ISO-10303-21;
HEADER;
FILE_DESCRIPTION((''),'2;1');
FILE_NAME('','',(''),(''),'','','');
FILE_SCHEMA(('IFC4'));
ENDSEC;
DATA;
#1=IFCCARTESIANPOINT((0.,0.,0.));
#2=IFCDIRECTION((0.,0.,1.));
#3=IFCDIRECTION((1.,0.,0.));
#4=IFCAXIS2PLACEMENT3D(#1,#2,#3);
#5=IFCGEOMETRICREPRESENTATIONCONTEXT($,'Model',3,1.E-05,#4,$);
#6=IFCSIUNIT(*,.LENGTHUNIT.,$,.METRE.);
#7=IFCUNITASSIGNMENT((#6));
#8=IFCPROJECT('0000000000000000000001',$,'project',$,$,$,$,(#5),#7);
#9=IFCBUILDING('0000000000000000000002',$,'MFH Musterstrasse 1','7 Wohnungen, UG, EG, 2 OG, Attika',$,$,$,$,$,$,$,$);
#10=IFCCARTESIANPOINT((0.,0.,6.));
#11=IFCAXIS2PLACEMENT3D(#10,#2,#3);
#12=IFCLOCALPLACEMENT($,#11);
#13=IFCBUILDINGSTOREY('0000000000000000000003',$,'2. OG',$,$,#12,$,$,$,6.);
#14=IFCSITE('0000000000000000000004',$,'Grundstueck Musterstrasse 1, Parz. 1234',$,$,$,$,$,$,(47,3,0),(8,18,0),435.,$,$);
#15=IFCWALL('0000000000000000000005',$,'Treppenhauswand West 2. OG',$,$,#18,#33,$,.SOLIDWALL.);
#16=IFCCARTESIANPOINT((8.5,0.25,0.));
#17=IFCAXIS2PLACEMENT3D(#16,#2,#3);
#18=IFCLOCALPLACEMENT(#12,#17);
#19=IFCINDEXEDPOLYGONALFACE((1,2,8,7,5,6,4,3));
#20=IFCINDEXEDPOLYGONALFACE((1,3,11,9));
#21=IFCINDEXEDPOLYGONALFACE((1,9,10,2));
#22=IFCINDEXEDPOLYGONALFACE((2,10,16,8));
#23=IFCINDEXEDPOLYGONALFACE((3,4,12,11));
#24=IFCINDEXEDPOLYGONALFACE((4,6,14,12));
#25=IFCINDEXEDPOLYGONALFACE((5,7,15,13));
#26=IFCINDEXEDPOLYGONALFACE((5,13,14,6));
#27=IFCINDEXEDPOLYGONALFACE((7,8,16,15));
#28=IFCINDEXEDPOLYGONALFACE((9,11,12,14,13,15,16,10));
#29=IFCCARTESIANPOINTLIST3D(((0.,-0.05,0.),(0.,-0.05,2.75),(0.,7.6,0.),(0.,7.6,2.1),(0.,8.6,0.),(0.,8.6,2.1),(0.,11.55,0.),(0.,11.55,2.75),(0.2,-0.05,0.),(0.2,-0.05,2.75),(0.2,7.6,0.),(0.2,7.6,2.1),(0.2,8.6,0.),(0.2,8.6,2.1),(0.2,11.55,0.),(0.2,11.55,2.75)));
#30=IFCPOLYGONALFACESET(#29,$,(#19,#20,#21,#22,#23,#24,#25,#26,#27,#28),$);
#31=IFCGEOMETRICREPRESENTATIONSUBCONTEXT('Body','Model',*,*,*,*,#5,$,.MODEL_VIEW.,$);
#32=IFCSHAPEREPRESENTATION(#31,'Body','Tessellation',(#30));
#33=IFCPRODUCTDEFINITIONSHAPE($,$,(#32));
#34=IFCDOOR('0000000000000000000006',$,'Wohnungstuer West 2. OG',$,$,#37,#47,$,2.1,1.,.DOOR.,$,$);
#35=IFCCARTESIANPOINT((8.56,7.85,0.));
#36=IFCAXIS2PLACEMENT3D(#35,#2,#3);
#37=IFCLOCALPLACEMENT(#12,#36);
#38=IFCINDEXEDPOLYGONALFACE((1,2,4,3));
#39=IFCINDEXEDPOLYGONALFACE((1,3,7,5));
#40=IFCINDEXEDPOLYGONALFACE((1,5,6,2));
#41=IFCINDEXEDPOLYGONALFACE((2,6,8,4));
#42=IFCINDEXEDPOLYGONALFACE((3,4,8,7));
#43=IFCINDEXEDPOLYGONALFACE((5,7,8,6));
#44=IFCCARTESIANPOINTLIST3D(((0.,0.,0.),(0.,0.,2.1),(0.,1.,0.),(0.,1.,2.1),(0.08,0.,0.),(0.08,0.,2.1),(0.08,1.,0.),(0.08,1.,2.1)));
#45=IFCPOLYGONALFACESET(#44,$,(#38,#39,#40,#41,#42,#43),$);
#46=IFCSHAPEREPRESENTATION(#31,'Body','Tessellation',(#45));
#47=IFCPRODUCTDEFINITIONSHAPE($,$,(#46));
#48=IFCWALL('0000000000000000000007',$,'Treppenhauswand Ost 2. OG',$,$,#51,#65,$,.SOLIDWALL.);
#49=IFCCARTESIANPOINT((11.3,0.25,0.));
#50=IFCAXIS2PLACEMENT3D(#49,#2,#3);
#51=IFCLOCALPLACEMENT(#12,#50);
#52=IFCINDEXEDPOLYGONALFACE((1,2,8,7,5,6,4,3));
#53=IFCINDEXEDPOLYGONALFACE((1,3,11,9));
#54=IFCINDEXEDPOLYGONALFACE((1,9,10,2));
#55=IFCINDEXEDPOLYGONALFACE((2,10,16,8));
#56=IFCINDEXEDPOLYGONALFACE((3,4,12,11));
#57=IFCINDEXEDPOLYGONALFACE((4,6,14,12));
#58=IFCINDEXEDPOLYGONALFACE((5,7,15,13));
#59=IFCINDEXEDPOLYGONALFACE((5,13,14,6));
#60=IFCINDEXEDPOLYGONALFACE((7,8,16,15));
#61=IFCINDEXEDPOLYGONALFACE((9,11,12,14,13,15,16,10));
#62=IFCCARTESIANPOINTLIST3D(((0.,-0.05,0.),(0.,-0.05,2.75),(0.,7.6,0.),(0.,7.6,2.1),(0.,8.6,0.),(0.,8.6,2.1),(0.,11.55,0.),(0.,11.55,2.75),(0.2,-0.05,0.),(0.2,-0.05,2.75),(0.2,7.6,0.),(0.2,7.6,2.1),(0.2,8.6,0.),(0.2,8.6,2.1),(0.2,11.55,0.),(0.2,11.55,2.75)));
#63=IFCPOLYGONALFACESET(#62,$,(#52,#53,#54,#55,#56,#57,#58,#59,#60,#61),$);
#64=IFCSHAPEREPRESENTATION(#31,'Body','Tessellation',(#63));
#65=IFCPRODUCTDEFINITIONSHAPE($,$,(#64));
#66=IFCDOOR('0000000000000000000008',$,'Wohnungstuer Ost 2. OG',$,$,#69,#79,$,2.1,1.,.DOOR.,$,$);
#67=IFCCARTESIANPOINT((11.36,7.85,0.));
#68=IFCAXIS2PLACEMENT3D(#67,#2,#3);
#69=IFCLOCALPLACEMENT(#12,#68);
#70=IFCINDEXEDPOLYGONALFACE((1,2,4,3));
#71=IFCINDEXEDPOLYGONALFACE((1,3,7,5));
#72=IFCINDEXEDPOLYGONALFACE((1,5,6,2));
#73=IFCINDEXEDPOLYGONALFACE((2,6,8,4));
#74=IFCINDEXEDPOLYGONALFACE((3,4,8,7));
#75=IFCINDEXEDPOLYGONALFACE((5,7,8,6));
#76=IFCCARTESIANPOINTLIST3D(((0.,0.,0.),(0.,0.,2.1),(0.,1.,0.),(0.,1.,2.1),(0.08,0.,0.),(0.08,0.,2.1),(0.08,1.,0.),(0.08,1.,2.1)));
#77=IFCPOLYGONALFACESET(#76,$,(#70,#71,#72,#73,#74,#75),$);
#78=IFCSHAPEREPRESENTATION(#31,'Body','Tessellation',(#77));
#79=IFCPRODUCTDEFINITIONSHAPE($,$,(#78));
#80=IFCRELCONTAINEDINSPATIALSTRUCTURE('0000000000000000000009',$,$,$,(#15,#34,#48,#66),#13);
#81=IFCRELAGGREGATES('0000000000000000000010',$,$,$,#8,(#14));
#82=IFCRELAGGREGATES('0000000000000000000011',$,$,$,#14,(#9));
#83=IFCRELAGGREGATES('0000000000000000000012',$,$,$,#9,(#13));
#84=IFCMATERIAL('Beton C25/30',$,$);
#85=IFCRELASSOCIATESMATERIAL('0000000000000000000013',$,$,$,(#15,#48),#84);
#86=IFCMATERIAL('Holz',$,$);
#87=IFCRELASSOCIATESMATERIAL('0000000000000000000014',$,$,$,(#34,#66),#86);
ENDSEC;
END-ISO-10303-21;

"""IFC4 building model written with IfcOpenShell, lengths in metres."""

from ifc_helpers import new_model, si_unit, frame, frame_2d, origin_with_axes, place, context, subcontext, project, spatial, rectangle, extrude, material, element, fill, save


model = new_model("IFC4")

# Units and contexts
model_context = context("Model", 3, precision=1e-05, world=origin_with_axes())
body_context = subcontext(model_context, "Body", "Model", "MODEL_VIEW")
ifc_project = project(units=[si_unit("LENGTHUNIT", "METRE")], contexts=[model_context])

# Site, building, storey
site = spatial("IfcSite", under=ifc_project, Name="Grundstueck Musterstrasse 1, Parz. 1234", RefLatitude=(47, 3, 0), RefLongitude=(8, 18, 0), RefElevation=435.0)
building = spatial("IfcBuilding", under=site, Name="MFH Musterstrasse 1", Description="7 Wohnungen, UG, EG, 2 OG, Attika")
storey_placement = place(None, frame((0.0, 0.0, 6.0), z_axis=(0.0, 0.0, 1.0), x_axis=(1.0, 0.0, 0.0)))
storey = spatial("IfcBuildingStorey", under=building, at=storey_placement, Name="2. OG", Elevation=6.0)

# Walls, openings, doors
ifc_material_1 = material(Name="Beton C25/30")
wall_1_placement = place(storey_placement, frame((8.5, 0.25, 0.0), z_axis=(0.0, 0.0, 1.0), x_axis=(1.0, 0.0, 0.0)))
wall_1 = element("IfcWall", 1, at=wall_1_placement, inside=storey, material=ifc_material_1, Name="Treppenhauswand West 2. OG", PredefinedType="SOLIDWALL", context=body_context, shape_type="SweptSolid", body=[
    extrude(rectangle(XDim=0.2, YDim=11.6, at=frame_2d((0.1, 5.75))), origin_with_axes(), (0.0, 0.0, 1.0), 2.75),
])
opening_1_placement = place(wall_1_placement, frame((-0.01, 7.6, 0.0), z_axis=(0.0, 0.0, 1.0), x_axis=(1.0, 0.0, 0.0)))
opening_1 = element("IfcOpeningElement", 2, at=opening_1_placement, cuts=wall_1, context=body_context, shape_type="SweptSolid", body=[
    extrude(rectangle(XDim=0.22, YDim=1.0, at=frame_2d((0.11, 0.5))), origin_with_axes(), (0.0, 0.0, 1.0), 2.1),
])
ifc_material_2 = material(Name="Holz")
door_1_placement = place(storey_placement, frame((8.56, 7.85, 0.0), z_axis=(0.0, 0.0, 1.0), x_axis=(1.0, 0.0, 0.0)))
door_1 = element("IfcDoor", 3, at=door_1_placement, inside=storey, material=ifc_material_2, Name="Wohnungstuer West 2. OG", OverallHeight=2.1, OverallWidth=1.0, PredefinedType="DOOR", context=body_context, shape_type="SweptSolid", body=[
    extrude(rectangle(XDim=0.08, YDim=1.0, at=frame_2d((0.04, 0.5))), origin_with_axes(), (0.0, 0.0, 1.0), 2.1),
])
fill(opening_1, door_1)
wall_2_placement = place(storey_placement, frame((11.3, 0.25, 0.0), z_axis=(0.0, 0.0, 1.0), x_axis=(1.0, 0.0, 0.0)))
wall_2 = element("IfcWall", 4, at=wall_2_placement, inside=storey, material=ifc_material_1, Name="Treppenhauswand Ost 2. OG", PredefinedType="SOLIDWALL", context=body_context, shape_type="SweptSolid", body=[
    extrude(rectangle(XDim=0.2, YDim=11.6, at=frame_2d((0.1, 5.75))), origin_with_axes(), (0.0, 0.0, 1.0), 2.75),
])
opening_2_placement = place(wall_2_placement, frame((-0.01, 7.6, 0.0), z_axis=(0.0, 0.0, 1.0), x_axis=(1.0, 0.0, 0.0)))
opening_2 = element("IfcOpeningElement", 5, at=opening_2_placement, cuts=wall_2, context=body_context, shape_type="SweptSolid", body=[
    extrude(rectangle(XDim=0.22, YDim=1.0, at=frame_2d((0.11, 0.5))), origin_with_axes(), (0.0, 0.0, 1.0), 2.1),
])
door_2_placement = place(storey_placement, frame((11.36, 7.85, 0.0), z_axis=(0.0, 0.0, 1.0), x_axis=(1.0, 0.0, 0.0)))
door_2 = element("IfcDoor", 6, at=door_2_placement, inside=storey, material=ifc_material_2, Name="Wohnungstuer Ost 2. OG", OverallHeight=2.1, OverallWidth=1.0, PredefinedType="DOOR", context=body_context, shape_type="SweptSolid", body=[
    extrude(rectangle(XDim=0.08, YDim=1.0, at=frame_2d((0.04, 0.5))), origin_with_axes(), (0.0, 0.0, 1.0), 2.1),
])
fill(opening_2, door_2)

save(model, "model.ifc")
